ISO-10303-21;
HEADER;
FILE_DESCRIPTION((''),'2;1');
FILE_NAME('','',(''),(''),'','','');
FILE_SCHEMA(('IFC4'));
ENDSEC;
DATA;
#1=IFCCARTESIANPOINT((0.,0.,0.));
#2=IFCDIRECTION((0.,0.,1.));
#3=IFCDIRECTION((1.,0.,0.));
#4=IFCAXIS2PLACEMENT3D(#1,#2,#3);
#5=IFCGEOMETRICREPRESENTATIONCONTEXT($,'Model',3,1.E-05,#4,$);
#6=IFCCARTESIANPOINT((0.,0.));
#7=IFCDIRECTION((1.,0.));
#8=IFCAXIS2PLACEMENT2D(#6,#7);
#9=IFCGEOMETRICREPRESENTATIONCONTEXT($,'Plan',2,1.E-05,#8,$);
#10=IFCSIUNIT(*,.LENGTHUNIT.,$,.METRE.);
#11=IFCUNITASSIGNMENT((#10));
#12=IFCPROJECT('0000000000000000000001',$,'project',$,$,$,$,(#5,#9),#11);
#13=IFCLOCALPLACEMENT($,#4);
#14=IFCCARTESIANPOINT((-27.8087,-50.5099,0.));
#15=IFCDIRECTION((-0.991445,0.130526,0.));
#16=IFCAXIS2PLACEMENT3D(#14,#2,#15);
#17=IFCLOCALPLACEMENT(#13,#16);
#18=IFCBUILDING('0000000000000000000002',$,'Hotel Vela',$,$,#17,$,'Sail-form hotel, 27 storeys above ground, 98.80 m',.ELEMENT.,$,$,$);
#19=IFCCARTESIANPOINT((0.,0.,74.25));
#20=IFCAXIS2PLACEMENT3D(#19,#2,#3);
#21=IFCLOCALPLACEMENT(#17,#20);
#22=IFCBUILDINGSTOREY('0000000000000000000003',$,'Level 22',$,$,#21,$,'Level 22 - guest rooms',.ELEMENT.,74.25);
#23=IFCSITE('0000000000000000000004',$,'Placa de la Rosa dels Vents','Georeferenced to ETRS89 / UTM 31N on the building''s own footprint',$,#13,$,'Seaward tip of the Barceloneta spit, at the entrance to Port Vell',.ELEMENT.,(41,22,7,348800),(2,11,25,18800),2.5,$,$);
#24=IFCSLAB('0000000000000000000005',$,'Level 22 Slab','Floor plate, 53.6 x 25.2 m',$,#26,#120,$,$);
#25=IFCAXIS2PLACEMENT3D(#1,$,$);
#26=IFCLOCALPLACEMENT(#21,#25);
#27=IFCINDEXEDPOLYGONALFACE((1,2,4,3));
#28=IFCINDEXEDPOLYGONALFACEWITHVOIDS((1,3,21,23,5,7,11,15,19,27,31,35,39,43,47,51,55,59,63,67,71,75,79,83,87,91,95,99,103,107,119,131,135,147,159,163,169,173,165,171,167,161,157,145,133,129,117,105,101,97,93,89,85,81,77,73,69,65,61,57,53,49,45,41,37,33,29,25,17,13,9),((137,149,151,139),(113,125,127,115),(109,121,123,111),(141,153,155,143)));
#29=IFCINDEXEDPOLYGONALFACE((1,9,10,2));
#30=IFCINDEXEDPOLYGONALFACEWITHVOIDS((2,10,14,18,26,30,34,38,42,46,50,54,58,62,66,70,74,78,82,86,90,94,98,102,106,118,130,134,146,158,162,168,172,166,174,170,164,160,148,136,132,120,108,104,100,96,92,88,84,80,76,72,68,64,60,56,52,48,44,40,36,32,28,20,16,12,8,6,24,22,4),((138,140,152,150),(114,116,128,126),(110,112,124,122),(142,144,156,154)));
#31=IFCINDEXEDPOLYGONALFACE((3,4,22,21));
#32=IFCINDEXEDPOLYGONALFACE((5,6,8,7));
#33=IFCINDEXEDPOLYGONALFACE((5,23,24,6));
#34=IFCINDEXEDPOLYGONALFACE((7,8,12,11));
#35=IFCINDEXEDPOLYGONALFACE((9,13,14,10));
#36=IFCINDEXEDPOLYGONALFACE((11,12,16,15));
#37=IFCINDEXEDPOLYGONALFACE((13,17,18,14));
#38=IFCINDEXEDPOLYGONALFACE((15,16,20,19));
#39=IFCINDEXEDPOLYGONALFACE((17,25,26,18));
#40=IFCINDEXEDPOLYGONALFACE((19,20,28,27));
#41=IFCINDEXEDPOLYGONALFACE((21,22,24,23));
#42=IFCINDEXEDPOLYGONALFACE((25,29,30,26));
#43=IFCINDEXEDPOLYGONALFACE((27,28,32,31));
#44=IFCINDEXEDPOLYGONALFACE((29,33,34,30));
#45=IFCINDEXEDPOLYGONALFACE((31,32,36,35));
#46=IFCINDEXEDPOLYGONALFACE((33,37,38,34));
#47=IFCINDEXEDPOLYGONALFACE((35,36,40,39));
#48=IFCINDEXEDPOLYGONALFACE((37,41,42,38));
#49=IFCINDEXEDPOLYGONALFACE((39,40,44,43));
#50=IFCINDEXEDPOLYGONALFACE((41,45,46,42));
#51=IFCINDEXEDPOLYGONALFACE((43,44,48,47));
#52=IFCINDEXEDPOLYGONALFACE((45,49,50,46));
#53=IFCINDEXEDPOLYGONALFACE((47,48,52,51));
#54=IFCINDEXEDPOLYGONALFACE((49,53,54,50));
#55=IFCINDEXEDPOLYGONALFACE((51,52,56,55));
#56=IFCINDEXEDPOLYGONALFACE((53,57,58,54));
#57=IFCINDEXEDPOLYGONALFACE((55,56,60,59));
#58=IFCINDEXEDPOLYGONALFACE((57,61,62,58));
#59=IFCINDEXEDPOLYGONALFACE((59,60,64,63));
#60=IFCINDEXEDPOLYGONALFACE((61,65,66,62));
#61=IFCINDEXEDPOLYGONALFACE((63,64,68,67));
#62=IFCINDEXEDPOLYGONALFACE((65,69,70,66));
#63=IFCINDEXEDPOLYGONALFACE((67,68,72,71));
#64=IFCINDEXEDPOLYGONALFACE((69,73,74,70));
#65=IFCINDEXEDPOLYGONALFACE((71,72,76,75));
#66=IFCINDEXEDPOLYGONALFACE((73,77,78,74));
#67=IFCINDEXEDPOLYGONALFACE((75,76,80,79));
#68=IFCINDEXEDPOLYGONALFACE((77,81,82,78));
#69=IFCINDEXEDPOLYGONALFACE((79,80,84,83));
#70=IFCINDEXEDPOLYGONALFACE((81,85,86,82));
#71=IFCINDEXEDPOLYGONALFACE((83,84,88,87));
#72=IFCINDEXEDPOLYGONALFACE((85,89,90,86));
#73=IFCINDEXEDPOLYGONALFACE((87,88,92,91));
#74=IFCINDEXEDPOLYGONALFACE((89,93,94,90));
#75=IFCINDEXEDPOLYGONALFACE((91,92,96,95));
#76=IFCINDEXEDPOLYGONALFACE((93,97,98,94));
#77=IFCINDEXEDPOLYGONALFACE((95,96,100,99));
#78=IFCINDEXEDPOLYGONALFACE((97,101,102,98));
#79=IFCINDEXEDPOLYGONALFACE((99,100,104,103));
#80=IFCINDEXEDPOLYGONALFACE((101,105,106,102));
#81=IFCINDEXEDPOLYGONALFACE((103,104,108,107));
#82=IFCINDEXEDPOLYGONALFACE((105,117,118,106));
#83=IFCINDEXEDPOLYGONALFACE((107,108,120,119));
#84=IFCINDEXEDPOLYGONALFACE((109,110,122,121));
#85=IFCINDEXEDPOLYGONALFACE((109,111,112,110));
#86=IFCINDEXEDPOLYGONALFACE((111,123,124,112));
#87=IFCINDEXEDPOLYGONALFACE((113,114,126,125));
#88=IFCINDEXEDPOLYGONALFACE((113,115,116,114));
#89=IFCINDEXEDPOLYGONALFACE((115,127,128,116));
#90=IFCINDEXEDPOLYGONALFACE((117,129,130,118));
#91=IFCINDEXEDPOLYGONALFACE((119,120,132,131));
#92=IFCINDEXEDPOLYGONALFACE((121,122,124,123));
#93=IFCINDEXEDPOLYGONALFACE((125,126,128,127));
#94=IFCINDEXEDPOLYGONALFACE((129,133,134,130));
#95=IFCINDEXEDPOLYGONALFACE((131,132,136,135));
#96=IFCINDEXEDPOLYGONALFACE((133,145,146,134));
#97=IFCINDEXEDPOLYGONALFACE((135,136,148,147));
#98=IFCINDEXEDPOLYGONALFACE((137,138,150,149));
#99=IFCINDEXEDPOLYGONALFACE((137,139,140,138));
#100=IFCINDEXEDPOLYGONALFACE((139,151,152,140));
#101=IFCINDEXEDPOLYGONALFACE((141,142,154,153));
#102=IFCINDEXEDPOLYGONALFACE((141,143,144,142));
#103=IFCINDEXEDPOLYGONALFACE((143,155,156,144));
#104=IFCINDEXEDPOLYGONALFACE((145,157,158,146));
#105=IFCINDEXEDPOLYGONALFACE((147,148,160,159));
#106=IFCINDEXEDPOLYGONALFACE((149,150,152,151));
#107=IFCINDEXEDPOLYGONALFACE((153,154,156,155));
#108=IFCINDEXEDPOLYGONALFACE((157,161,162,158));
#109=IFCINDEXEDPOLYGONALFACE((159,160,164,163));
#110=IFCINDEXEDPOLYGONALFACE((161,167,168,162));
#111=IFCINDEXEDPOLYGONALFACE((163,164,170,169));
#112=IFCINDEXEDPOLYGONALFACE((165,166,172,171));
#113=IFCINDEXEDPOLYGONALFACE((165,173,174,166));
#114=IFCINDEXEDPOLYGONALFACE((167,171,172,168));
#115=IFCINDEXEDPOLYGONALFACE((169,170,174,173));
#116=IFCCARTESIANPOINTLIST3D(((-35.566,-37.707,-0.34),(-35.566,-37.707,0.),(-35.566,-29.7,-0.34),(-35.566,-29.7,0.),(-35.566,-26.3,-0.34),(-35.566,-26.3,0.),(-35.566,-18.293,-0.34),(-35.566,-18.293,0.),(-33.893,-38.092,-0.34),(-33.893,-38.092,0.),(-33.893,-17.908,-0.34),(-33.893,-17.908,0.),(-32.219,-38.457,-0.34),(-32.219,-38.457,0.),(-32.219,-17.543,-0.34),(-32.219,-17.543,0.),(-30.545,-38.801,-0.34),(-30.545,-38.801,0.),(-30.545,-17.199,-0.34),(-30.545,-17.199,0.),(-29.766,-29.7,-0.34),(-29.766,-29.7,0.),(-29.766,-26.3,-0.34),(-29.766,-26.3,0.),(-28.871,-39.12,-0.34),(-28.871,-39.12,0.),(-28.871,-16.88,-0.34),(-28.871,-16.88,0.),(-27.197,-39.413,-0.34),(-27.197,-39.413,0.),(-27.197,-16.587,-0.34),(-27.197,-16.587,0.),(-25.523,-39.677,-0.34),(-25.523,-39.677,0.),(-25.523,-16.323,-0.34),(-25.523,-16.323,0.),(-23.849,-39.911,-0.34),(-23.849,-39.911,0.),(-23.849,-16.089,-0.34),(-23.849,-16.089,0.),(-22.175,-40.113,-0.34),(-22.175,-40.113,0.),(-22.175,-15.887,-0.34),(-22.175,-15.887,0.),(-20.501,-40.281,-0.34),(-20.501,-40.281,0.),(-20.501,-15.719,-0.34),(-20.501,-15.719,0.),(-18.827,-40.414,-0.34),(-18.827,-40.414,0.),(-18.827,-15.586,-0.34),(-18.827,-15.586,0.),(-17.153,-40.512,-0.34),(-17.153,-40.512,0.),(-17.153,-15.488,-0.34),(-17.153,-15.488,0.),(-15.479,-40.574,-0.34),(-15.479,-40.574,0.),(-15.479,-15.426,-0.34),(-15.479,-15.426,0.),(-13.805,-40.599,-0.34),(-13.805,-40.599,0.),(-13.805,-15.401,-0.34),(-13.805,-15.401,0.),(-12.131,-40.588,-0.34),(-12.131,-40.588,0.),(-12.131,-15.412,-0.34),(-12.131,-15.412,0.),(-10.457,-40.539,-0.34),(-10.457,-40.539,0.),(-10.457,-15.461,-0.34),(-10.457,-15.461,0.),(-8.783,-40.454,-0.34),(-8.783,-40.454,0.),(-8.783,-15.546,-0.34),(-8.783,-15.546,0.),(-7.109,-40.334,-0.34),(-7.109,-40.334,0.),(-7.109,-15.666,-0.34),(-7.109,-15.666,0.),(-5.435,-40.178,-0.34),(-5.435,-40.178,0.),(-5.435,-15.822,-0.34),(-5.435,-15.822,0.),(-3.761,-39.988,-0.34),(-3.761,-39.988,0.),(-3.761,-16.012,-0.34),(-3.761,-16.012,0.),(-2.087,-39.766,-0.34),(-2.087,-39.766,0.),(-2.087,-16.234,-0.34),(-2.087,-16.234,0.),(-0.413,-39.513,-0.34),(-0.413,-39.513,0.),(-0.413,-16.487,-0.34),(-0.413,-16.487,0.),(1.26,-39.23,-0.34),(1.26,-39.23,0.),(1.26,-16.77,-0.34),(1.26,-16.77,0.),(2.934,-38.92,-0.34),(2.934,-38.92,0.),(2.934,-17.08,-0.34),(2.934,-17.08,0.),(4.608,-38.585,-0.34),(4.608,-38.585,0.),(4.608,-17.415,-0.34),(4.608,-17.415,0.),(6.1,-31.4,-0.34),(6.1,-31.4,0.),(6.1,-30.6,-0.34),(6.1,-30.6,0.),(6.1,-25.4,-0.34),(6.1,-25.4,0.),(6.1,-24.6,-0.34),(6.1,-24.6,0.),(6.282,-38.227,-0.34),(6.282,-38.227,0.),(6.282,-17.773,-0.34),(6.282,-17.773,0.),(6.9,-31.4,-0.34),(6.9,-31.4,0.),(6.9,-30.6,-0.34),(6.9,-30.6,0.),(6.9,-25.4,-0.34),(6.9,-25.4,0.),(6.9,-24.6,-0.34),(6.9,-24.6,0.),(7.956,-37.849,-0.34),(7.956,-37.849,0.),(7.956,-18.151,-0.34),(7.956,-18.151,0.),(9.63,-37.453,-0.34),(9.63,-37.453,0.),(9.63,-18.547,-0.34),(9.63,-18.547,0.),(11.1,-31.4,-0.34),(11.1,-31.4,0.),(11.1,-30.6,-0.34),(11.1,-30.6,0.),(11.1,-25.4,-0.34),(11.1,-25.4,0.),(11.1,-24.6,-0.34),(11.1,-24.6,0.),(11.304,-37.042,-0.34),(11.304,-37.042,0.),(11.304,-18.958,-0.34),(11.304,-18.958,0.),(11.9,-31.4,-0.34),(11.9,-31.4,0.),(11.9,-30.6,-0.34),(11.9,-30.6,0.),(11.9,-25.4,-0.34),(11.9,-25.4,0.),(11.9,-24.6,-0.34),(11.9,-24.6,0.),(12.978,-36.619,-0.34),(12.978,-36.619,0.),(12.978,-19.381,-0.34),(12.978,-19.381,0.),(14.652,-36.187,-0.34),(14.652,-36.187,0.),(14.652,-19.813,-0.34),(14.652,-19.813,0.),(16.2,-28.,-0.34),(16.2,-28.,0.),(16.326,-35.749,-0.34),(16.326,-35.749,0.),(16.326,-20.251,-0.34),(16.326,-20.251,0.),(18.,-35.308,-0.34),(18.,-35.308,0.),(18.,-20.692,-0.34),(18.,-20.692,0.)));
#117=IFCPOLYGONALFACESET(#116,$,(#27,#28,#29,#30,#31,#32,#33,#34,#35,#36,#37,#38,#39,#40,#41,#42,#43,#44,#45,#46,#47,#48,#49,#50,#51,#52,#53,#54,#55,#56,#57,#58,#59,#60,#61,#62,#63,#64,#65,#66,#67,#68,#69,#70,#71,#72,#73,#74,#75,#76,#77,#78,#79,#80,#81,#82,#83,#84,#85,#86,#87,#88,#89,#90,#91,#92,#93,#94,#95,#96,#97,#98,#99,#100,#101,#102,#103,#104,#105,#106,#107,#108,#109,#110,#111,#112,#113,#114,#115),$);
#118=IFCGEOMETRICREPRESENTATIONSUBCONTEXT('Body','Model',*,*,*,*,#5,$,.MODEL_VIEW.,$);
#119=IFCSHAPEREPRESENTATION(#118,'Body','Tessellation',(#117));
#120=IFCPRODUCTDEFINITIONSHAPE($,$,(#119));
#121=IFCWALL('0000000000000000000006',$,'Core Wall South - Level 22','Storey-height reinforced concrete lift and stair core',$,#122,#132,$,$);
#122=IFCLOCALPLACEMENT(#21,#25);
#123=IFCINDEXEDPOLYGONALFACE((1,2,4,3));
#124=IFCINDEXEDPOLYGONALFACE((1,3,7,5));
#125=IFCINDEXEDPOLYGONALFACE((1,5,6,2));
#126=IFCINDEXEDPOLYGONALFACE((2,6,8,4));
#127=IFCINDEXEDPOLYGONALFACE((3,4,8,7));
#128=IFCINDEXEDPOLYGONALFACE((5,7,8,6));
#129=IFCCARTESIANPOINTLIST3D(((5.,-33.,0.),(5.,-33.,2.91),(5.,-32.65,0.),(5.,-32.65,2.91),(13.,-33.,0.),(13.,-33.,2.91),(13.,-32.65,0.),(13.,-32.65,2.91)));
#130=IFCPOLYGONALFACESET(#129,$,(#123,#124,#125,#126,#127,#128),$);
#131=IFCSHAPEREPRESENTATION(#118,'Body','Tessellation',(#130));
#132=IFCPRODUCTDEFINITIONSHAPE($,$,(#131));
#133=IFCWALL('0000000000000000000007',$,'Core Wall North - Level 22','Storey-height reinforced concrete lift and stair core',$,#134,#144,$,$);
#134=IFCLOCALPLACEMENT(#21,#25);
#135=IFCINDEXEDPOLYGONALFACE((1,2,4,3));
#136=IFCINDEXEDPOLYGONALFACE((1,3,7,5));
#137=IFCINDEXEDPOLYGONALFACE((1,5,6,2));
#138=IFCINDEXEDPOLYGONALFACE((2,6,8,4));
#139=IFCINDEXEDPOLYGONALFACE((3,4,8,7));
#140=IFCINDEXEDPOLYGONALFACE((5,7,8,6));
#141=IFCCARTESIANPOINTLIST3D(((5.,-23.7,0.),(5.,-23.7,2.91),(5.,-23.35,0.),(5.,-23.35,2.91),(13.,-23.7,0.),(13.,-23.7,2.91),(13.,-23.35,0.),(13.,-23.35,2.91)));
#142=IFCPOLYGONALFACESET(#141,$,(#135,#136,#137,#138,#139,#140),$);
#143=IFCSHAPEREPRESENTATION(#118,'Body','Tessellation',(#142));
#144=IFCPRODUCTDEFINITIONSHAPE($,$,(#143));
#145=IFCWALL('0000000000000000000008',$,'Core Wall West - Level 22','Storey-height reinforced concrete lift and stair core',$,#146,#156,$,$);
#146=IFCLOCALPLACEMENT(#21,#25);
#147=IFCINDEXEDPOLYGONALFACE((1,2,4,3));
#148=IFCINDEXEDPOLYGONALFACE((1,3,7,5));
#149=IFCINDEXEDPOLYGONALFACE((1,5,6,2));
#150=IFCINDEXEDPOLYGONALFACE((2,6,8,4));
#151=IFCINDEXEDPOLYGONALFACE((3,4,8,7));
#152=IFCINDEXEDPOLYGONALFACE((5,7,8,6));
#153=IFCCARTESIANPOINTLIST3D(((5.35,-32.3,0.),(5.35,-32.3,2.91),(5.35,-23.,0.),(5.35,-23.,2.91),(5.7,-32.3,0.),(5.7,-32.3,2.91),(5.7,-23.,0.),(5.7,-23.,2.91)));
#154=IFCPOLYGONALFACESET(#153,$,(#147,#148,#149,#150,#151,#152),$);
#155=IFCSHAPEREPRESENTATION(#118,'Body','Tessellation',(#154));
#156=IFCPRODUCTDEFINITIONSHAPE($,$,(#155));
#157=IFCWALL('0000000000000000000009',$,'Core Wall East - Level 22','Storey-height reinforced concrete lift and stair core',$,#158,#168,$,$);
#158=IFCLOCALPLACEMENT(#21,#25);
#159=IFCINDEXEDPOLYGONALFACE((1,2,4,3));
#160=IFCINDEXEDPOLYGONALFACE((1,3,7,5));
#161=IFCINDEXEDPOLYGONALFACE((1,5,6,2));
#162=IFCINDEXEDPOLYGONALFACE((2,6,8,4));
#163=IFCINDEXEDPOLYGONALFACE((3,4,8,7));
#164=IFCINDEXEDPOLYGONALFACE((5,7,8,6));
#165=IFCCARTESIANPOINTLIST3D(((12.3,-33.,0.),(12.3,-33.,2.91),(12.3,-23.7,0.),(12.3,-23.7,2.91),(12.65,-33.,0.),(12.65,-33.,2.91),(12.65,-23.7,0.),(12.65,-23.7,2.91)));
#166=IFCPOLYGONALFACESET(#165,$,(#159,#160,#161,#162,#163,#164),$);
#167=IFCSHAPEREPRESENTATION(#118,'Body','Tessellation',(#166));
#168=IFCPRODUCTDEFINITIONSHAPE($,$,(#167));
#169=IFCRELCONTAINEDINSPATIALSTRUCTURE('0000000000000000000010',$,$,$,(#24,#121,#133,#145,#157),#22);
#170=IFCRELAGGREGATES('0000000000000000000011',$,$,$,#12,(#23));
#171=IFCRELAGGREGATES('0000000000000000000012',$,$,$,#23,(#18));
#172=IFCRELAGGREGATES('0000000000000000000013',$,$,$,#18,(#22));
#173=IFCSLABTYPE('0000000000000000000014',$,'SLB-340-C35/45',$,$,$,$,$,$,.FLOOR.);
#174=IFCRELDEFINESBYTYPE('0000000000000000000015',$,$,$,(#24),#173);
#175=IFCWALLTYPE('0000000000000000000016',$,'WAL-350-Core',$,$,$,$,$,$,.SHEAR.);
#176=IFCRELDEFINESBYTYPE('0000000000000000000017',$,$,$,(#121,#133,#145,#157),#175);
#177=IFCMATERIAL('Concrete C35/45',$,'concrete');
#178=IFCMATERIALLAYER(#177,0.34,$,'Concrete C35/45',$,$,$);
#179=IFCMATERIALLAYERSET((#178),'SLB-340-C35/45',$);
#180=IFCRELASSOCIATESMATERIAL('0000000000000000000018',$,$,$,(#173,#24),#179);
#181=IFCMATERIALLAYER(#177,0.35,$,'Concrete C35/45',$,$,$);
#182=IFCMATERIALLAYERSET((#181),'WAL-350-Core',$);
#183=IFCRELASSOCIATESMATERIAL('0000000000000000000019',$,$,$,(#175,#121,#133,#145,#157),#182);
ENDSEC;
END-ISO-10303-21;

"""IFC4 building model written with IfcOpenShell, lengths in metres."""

from ifc_helpers import new_model, si_unit, frame, origin_with_axes, origin_2d_with_axis, place, context, subcontext, project, spatial, line, indexed_curve, outline, extrude, material, layer, layer_set, layer_usage, type_object, element, save


model = new_model("IFC4")

# Units and contexts
model_context = context("Model", 3, precision=1e-05, world=origin_with_axes())
plan_context = context("Plan", 2, precision=1e-05, world=origin_2d_with_axis())
body_context = subcontext(model_context, "Body", "Model", "MODEL_VIEW")
ifc_project = project(units=[si_unit("LENGTHUNIT", "METRE")], contexts=[model_context, plan_context])

# Site, building, storey
site_placement = place(None, origin_with_axes())
site = spatial("IfcSite", under=ifc_project, at=site_placement, Name="Placa de la Rosa dels Vents", Description="Georeferenced to ETRS89 / UTM 31N on the building's own footprint", LongName="Seaward tip of the Barceloneta spit, at the entrance to Port Vell", CompositionType="ELEMENT", RefLatitude=(41, 22, 7, 348800), RefLongitude=(2, 11, 25, 18800), RefElevation=2.5)
building_placement = place(site_placement, frame((-27.8087, -50.5099, 0.0), z_axis=(0.0, 0.0, 1.0), x_axis=(-0.991445, 0.130526, 0.0)))
building = spatial("IfcBuilding", under=site, at=building_placement, Name="Hotel Vela", LongName="Sail-form hotel, 27 storeys above ground, 98.80 m", CompositionType="ELEMENT")
storey_placement = place(building_placement, frame((0.0, 0.0, 74.25), z_axis=(0.0, 0.0, 1.0), x_axis=(1.0, 0.0, 0.0)))
storey = spatial("IfcBuildingStorey", under=building, at=storey_placement, Name="Level 22", LongName="Level 22 - guest rooms", CompositionType="ELEMENT", Elevation=74.25)

# Shared definitions
ifc_material = material(Name="Concrete C35/45", Category="concrete")

# Slab, openings
ifc_layer_1 = layer(ifc_material, 0.34, Name="Concrete C35/45")
ifc_layer_set_1 = layer_set([ifc_layer_1], Name="SLB-340-C35/45")
ifc_layer_usage_1 = layer_usage(ifc_layer_set_1, "AXIS3", "POSITIVE", 0.0)
slab_type = type_object("IfcSlabType", Name="SLB-340-C35/45", PredefinedType="FLOOR", material=ifc_layer_set_1)
slab_placement = place(storey_placement, frame((0.0, 0.0, -0.34), z_axis=(0.0, 0.0, 1.0), x_axis=(1.0, 0.0, 0.0)))
slab = element("IfcSlab", 1, at=slab_placement, inside=storey, type_object=slab_type, material=ifc_layer_usage_1, Name="Level 22 Slab", Description="Floor plate, 53.6 x 25.2 m", context=body_context, shape_type="SweptSolid", body=[
    extrude(outline(indexed_curve([(-35.566, -37.707), (-33.893, -38.092), (-32.219, -38.457), (-30.545, -38.801), (-28.871, -39.12), (-27.197, -39.413), (-25.523, -39.677), (-23.849, -39.911), (-22.175, -40.113), (-20.501, -40.281), (-18.827, -40.414), (-17.153, -40.512), (-15.479, -40.574), (-13.805, -40.599), (-12.131, -40.588), (-10.457, -40.539), (-8.783, -40.454), (-7.109, -40.334), (-5.435, -40.178), (-3.761, -39.988), (-2.087, -39.766), (-0.413, -39.513), (1.26, -39.23), (2.934, -38.92), (4.608, -38.585), (6.282, -38.227), (7.956, -37.849), (9.63, -37.453), (11.304, -37.042), (12.978, -36.619), (14.652, -36.187), (16.326, -35.749), (18.0, -35.308), (16.2, -28.0), (18.0, -20.692), (16.326, -20.251), (14.652, -19.813), (12.978, -19.381), (11.304, -18.958), (9.63, -18.547), (7.956, -18.151), (6.282, -17.773), (4.608, -17.415), (2.934, -17.08), (1.26, -16.77), (-0.413, -16.487), (-2.087, -16.234), (-3.761, -16.012), (-5.435, -15.822), (-7.109, -15.666), (-8.783, -15.546), (-10.457, -15.461), (-12.131, -15.412), (-13.805, -15.401), (-15.479, -15.426), (-17.153, -15.488), (-18.827, -15.586), (-20.501, -15.719), (-22.175, -15.887), (-23.849, -16.089), (-25.523, -16.323), (-27.197, -16.587), (-28.871, -16.88), (-30.545, -17.199), (-32.219, -17.543), (-33.893, -17.908), (-35.566, -18.293), (-35.566, -26.3), (-29.766, -26.3), (-29.766, -29.7), (-35.566, -29.7)], segments=[line(1, 2, 3, 4, 5, 6, 7, 8, 9, 10, 11, 12, 13, 14, 15, 16, 17, 18, 19, 20, 21, 22, 23, 24, 25, 26, 27, 28, 29, 30, 31, 32, 33, 34, 35, 36, 37, 38, 39, 40, 41, 42, 43, 44, 45, 46, 47, 48, 49, 50, 51, 52, 53, 54, 55, 56, 57, 58, 59, 60, 61, 62, 63, 64, 65, 66, 67, 68, 69, 70, 71, 1)])), origin_with_axes(), (0.0, 0.0, 1.0), 0.34),
])
opening_1_placement = place(slab_placement, frame((6.1, -31.4, -0.05), z_axis=(0.0, 0.0, 1.0), x_axis=(1.0, 0.0, 0.0)))
element("IfcOpeningElement", 2, at=opening_1_placement, cuts=slab, PredefinedType="OPENING", context=body_context, shape_type="SweptSolid", body=[
    extrude(outline(indexed_curve([(0.0, 0.0), (0.8, 0.0), (0.8, 0.8), (0.0, 0.8)], segments=[line(1, 2, 3, 4, 1)])), origin_with_axes(), (0.0, 0.0, 1.0), 0.44),
])
opening_2_placement = place(slab_placement, frame((6.1, -25.4, -0.05), z_axis=(0.0, 0.0, 1.0), x_axis=(1.0, 0.0, 0.0)))
element("IfcOpeningElement", 3, at=opening_2_placement, cuts=slab, PredefinedType="OPENING", context=body_context, shape_type="SweptSolid", body=[
    extrude(outline(indexed_curve([(0.0, 0.0), (0.8, 0.0), (0.8, 0.8), (0.0, 0.8)], segments=[line(1, 2, 3, 4, 1)])), origin_with_axes(), (0.0, 0.0, 1.0), 0.44),
])
opening_3_placement = place(slab_placement, frame((11.1, -31.4, -0.05), z_axis=(0.0, 0.0, 1.0), x_axis=(1.0, 0.0, 0.0)))
element("IfcOpeningElement", 4, at=opening_3_placement, cuts=slab, PredefinedType="OPENING", context=body_context, shape_type="SweptSolid", body=[
    extrude(outline(indexed_curve([(0.0, 0.0), (0.8, 0.0), (0.8, 0.8), (0.0, 0.8)], segments=[line(1, 2, 3, 4, 1)])), origin_with_axes(), (0.0, 0.0, 1.0), 0.44),
])
opening_4_placement = place(slab_placement, frame((11.1, -25.4, -0.05), z_axis=(0.0, 0.0, 1.0), x_axis=(1.0, 0.0, 0.0)))
element("IfcOpeningElement", 5, at=opening_4_placement, cuts=slab, PredefinedType="OPENING", context=body_context, shape_type="SweptSolid", body=[
    extrude(outline(indexed_curve([(0.0, 0.0), (0.8, 0.0), (0.8, 0.8), (0.0, 0.8)], segments=[line(1, 2, 3, 4, 1)])), origin_with_axes(), (0.0, 0.0, 1.0), 0.44),
])

# Walls
ifc_layer_2 = layer(ifc_material, 0.35, Name="Concrete C35/45")
ifc_layer_set_2 = layer_set([ifc_layer_2], Name="WAL-350-Core")
ifc_layer_usage_2 = layer_usage(ifc_layer_set_2, "AXIS2", "POSITIVE", 0.0)
wall_type = type_object("IfcWallType", Name="WAL-350-Core", PredefinedType="SHEAR", material=ifc_layer_set_2)
wall_1_placement = place(storey_placement, frame((5.0, -33.0, 0.0), z_axis=(0.0, 0.0, 1.0), x_axis=(1.0, 0.0, 0.0)))
element("IfcWall", 6, at=wall_1_placement, inside=storey, type_object=wall_type, material=ifc_layer_usage_2, Name="Core Wall South - Level 22", Description="Storey-height reinforced concrete lift and stair core", context=body_context, shape_type="SweptSolid", body=[
    extrude(outline(indexed_curve([(0.0, 0.0), (8.0, 0.0), (8.0, 0.35), (0.0, 0.35)], segments=[line(1, 2, 3, 4, 1)])), origin_with_axes(), (0.0, 0.0, 1.0), 2.91),
])
ifc_layer_usage_3 = layer_usage(ifc_layer_set_2, "AXIS2", "POSITIVE", 0.0)
wall_2_placement = place(storey_placement, frame((13.0, -23.35, 0.0), z_axis=(0.0, 0.0, 1.0), x_axis=(-1.0, 0.0, 0.0)))
element("IfcWall", 7, at=wall_2_placement, inside=storey, type_object=wall_type, material=ifc_layer_usage_3, Name="Core Wall North - Level 22", Description="Storey-height reinforced concrete lift and stair core", context=body_context, shape_type="SweptSolid", body=[
    extrude(outline(indexed_curve([(0.0, 0.0), (8.0, 0.0), (8.0, 0.35), (0.0, 0.35)], segments=[line(1, 2, 3, 4, 1)])), origin_with_axes(), (0.0, 0.0, 1.0), 2.91),
])
ifc_layer_usage_4 = layer_usage(ifc_layer_set_2, "AXIS2", "POSITIVE", 0.0)
wall_3_placement = place(storey_placement, frame((5.35, -23.0, 0.0), z_axis=(0.0, 0.0, 1.0), x_axis=(0.0, -1.0, 0.0)))
element("IfcWall", 8, at=wall_3_placement, inside=storey, type_object=wall_type, material=ifc_layer_usage_4, Name="Core Wall West - Level 22", Description="Storey-height reinforced concrete lift and stair core", context=body_context, shape_type="SweptSolid", body=[
    extrude(outline(indexed_curve([(0.0, 0.0), (9.3, 0.0), (9.3, 0.35), (0.0, 0.35)], segments=[line(1, 2, 3, 4, 1)])), origin_with_axes(), (0.0, 0.0, 1.0), 2.91),
])
ifc_layer_usage_5 = layer_usage(ifc_layer_set_2, "AXIS2", "POSITIVE", 0.0)
wall_4_placement = place(storey_placement, frame((12.65, -33.0, 0.0), z_axis=(0.0, 0.0, 1.0), x_axis=(0.0, 1.0, 0.0)))
element("IfcWall", 9, at=wall_4_placement, inside=storey, type_object=wall_type, material=ifc_layer_usage_5, Name="Core Wall East - Level 22", Description="Storey-height reinforced concrete lift and stair core", context=body_context, shape_type="SweptSolid", body=[
    extrude(outline(indexed_curve([(0.0, 0.0), (9.3, 0.0), (9.3, 0.35), (0.0, 0.35)], segments=[line(1, 2, 3, 4, 1)])), origin_with_axes(), (0.0, 0.0, 1.0), 2.91),
])

save(model, "model.ifc")
